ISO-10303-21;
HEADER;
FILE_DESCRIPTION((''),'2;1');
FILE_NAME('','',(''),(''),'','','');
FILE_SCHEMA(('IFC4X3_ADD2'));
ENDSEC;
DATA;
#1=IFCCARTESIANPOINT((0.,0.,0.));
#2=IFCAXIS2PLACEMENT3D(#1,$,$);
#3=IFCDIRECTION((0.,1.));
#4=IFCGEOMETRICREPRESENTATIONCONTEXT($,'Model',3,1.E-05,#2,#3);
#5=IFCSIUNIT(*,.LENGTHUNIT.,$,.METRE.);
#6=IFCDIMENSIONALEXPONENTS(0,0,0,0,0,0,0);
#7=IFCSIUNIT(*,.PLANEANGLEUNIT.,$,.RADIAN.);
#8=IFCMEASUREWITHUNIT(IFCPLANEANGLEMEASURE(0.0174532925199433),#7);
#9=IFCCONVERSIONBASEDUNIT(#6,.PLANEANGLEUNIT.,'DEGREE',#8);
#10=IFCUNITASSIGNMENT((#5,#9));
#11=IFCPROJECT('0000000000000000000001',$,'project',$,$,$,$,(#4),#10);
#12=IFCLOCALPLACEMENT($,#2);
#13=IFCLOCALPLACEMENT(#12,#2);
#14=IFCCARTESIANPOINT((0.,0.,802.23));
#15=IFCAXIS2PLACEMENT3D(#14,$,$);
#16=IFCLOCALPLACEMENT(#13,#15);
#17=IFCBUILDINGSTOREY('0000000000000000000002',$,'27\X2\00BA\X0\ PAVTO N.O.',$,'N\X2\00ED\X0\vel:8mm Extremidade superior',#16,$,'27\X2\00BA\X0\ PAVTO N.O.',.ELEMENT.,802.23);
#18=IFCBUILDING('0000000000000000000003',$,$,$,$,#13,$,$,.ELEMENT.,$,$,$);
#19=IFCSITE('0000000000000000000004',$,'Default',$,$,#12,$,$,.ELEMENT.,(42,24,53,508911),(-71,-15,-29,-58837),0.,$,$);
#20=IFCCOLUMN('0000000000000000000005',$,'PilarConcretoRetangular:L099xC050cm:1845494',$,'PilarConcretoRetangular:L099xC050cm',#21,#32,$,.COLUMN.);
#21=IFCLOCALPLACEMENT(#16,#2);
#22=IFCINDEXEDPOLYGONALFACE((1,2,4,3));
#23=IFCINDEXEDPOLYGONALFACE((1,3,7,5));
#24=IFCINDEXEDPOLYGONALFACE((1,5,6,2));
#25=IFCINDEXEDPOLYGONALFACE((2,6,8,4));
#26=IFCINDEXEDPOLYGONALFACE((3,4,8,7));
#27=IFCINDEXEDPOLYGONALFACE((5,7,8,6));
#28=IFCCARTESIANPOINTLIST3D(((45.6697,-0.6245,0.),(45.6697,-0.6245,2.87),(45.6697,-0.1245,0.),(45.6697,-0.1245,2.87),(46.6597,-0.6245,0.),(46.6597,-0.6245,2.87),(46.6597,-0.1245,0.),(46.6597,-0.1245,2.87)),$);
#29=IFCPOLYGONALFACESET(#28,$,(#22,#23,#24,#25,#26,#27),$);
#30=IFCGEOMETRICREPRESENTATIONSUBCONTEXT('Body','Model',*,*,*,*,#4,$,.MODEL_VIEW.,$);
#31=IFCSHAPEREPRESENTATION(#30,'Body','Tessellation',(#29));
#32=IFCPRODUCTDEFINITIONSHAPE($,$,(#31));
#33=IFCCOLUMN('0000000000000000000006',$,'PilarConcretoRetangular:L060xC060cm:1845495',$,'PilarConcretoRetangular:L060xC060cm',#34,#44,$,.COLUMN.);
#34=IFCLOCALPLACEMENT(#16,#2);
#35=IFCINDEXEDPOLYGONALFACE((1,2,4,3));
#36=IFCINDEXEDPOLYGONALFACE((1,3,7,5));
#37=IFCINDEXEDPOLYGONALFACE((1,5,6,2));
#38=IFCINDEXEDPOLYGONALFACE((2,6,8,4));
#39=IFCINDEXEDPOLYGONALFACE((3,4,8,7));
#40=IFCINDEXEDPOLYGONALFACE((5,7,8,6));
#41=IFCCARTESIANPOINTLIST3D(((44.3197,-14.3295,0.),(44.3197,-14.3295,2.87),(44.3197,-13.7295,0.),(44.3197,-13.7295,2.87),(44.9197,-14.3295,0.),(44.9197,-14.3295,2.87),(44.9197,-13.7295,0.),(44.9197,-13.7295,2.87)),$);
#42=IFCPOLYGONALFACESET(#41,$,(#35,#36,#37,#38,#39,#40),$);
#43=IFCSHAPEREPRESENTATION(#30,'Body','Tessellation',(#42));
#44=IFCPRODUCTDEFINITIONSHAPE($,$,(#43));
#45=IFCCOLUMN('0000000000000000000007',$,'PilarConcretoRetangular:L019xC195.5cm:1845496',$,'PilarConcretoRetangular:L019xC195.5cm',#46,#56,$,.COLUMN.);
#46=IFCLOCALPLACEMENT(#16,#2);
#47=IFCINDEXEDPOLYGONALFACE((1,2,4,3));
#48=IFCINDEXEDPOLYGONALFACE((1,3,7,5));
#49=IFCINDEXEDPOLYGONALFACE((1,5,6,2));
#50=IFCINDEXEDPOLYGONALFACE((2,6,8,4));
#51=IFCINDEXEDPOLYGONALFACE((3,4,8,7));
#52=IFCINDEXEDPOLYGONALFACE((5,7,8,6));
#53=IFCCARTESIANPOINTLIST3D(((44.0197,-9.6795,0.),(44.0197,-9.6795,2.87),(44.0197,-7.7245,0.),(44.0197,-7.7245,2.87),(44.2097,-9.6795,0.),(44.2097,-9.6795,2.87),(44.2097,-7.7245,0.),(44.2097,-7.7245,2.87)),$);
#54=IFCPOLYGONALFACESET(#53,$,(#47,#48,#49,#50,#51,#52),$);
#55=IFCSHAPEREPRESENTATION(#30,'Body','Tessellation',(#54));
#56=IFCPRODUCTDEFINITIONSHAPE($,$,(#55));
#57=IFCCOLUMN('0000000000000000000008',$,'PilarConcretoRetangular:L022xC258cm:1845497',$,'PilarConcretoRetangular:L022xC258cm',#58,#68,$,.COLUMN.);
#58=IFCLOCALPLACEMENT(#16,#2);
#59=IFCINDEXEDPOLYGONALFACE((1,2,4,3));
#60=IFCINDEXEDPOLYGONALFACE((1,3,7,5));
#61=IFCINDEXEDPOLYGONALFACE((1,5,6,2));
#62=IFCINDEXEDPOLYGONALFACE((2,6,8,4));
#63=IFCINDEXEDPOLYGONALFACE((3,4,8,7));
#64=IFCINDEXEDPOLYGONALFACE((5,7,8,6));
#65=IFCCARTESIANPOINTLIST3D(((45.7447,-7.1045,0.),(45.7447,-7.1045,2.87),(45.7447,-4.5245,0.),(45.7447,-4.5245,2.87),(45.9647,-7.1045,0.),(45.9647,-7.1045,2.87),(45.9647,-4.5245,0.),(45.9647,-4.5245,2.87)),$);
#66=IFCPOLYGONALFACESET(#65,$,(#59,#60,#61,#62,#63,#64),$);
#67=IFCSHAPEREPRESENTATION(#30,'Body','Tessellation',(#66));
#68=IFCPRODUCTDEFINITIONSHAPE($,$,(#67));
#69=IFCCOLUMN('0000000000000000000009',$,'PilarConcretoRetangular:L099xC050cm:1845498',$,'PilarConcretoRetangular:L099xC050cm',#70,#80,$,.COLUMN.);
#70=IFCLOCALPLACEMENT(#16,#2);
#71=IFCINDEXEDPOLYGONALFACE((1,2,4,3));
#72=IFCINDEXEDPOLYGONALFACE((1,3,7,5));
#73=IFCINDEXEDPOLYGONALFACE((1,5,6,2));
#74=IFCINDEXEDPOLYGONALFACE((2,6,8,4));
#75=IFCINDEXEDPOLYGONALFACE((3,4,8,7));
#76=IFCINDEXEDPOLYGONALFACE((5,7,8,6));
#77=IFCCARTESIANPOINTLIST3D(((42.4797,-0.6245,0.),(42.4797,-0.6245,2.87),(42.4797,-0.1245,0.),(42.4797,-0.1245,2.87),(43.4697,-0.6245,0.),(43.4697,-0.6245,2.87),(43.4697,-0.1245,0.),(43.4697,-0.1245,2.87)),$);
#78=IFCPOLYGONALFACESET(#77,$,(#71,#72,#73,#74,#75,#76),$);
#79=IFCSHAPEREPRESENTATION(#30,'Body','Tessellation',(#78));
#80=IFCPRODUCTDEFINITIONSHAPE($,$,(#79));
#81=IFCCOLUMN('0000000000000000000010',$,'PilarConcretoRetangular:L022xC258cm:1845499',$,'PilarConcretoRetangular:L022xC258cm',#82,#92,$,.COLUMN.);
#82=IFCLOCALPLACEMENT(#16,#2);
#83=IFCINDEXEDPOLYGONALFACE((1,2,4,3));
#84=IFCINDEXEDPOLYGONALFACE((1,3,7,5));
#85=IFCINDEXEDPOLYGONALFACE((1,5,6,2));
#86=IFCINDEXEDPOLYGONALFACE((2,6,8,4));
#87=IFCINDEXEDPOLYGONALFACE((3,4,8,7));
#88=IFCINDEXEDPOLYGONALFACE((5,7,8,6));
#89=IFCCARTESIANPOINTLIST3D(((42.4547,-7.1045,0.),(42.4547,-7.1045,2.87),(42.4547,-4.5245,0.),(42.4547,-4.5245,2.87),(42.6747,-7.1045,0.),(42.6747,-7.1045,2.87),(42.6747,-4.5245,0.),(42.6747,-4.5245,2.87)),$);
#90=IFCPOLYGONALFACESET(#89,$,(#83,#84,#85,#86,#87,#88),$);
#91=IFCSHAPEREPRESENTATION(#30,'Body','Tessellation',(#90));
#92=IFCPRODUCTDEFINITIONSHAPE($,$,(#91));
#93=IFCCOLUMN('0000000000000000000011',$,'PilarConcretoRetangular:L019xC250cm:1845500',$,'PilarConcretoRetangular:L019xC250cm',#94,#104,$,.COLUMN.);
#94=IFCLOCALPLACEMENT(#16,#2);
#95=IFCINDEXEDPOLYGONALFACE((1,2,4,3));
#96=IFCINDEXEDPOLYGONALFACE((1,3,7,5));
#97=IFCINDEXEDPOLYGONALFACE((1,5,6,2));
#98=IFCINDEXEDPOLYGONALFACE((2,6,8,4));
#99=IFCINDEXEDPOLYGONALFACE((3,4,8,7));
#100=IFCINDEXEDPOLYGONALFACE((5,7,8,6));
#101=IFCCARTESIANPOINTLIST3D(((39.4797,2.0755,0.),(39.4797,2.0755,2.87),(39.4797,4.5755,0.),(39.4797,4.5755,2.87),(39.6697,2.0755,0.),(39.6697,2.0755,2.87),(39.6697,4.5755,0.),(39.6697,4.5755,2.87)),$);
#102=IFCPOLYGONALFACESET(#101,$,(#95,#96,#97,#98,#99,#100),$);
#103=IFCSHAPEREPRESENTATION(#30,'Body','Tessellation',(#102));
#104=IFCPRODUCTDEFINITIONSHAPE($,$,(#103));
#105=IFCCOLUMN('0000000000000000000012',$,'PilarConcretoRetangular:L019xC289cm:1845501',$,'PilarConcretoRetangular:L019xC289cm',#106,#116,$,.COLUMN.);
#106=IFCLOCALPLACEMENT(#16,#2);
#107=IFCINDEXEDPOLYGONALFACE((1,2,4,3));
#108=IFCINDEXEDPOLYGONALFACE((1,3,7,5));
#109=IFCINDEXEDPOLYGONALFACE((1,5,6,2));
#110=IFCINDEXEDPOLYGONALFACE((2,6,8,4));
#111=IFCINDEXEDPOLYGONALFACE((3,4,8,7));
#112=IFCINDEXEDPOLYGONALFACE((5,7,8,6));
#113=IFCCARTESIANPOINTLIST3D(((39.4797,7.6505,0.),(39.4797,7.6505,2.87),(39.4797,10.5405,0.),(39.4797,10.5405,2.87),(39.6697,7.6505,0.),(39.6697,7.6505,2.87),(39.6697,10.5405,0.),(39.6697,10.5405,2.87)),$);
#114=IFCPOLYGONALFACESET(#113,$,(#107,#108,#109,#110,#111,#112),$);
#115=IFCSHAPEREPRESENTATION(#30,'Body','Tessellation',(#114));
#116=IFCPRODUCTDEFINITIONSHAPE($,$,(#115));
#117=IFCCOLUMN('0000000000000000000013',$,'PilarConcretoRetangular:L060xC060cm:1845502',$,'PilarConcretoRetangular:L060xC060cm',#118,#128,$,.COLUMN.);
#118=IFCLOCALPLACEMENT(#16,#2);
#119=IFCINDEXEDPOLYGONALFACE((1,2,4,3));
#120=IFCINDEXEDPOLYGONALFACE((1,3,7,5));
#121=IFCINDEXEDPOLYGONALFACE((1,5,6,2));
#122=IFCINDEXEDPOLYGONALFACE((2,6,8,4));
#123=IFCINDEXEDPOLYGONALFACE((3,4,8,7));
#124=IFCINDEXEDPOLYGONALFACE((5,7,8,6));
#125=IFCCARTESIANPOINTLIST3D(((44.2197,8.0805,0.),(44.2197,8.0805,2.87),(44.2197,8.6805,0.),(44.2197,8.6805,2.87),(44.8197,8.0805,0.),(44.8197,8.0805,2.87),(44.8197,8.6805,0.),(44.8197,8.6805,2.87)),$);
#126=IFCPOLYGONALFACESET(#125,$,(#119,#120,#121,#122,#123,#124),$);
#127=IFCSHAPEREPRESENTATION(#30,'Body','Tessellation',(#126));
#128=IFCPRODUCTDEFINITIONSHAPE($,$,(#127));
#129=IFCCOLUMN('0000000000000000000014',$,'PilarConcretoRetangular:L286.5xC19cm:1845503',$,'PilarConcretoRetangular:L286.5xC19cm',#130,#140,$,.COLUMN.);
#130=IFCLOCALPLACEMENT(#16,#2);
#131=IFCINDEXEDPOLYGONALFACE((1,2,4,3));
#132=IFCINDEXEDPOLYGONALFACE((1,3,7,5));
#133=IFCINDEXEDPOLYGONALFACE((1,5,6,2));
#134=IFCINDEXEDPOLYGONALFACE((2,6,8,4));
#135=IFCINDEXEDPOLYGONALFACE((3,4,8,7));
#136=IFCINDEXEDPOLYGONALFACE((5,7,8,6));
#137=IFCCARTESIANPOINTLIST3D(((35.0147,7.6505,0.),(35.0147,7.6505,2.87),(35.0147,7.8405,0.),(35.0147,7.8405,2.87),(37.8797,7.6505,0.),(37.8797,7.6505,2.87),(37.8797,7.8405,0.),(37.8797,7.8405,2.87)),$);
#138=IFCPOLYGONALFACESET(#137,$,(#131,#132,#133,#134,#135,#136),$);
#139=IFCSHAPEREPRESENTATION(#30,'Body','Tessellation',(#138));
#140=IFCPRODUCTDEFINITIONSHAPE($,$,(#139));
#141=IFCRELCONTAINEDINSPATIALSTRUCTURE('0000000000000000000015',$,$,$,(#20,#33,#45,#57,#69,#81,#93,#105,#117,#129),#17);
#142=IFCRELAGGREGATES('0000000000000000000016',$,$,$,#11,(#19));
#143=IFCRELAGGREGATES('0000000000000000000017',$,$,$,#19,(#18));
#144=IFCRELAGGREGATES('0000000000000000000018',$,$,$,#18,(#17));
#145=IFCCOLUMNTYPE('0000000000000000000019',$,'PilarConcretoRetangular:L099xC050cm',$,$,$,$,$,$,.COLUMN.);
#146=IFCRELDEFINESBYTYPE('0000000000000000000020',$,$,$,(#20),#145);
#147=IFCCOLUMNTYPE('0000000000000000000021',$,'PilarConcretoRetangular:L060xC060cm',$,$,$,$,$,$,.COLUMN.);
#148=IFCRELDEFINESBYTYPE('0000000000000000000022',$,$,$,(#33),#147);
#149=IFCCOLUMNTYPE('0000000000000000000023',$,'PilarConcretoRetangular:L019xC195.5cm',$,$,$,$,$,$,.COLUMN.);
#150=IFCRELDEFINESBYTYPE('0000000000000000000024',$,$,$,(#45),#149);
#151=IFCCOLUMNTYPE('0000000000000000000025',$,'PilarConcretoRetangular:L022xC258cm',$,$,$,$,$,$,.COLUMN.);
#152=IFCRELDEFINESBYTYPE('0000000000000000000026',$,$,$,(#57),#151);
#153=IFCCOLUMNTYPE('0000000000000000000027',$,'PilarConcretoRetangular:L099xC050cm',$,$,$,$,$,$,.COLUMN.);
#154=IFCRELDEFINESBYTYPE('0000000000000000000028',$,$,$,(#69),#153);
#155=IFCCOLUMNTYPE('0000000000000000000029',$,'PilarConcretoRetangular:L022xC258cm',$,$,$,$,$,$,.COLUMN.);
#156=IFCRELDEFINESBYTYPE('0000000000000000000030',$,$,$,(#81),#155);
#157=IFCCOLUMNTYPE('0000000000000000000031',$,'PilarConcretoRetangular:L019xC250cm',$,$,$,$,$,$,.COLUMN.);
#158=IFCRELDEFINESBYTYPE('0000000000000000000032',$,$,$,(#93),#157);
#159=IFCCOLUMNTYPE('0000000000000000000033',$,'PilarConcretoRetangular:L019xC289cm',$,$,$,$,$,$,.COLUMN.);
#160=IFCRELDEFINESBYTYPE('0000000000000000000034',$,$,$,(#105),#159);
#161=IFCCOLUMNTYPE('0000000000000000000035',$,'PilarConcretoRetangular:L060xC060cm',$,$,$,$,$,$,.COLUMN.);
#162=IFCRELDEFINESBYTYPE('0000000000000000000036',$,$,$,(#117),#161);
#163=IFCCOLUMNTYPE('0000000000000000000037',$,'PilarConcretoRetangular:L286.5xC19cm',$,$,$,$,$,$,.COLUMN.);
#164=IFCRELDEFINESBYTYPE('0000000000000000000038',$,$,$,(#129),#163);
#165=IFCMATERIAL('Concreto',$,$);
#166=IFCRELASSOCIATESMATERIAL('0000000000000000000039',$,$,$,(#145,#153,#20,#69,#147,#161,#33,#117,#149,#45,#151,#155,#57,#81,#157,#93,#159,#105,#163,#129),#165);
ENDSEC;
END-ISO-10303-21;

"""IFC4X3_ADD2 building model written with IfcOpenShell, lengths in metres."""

from ifc_helpers import new_model, entity, si_unit, converted_unit, direction, frame, frame_2d, origin, origin_2d_with_axis, place, context, subcontext, project, spatial, rectangle, extrude, source, transform, mapped, material, material_profile, profile_set, profile_usage, type_object, type_shapes, element, save


model = new_model("IFC4X3_ADD2")

# Units and contexts
model_context = context("Model", 3, precision=1e-05, world=origin(), true_north=direction((0.0, 1.0)))
body_context = subcontext(model_context, "Body", "Model", "MODEL_VIEW")
ifc_project = project(units=[si_unit("LENGTHUNIT", "METRE"), converted_unit("PLANEANGLEUNIT", "DEGREE", entity("IfcPlaneAngleMeasure", 0.0174532925199433), si_unit("PLANEANGLEUNIT", "RADIAN"), dimensions=[0, 0, 0, 0, 0, 0, 0])], contexts=[model_context])

# Site, building, storey
site_placement = place(None, origin())
site = spatial("IfcSite", under=ifc_project, at=site_placement, Name="Default", CompositionType="ELEMENT", RefLatitude=(42, 24, 53, 508911), RefLongitude=(-71, -15, -29, -58837), RefElevation=0.0)
building_placement = place(site_placement, origin())
building = spatial("IfcBuilding", under=site, at=building_placement, CompositionType="ELEMENT")
storey_placement = place(building_placement, frame((0.0, 0.0, 802.23)))
storey = spatial("IfcBuildingStorey", under=building, at=storey_placement, Name="27º PAVTO N.O.", ObjectType="Nível:8mm Extremidade superior", LongName="27º PAVTO N.O.", CompositionType="ELEMENT", Elevation=802.23)

# Columns
ifc_material = material(Name="Concreto")
ifc_material_profile_1 = material_profile(ifc_material, rectangle(XDim=0.19, YDim=2.89, at=frame_2d((0.0, 0.0), x_axis=(1.0, 0.0))), Name="L019xC289cm")
ifc_profile_set_1 = profile_set([ifc_material_profile_1], Name="L019xC289cm")
ifc_profile_usage_1 = profile_usage(ifc_profile_set_1)
ifc_material_profile_2 = material_profile(ifc_material, rectangle(XDim=0.19, YDim=2.5, at=frame_2d((0.0, 0.0), x_axis=(1.0, 0.0))), Name="L019xC250cm")
ifc_profile_set_2 = profile_set([ifc_material_profile_2], Name="L019xC250cm")
ifc_profile_usage_2 = profile_usage(ifc_profile_set_2)
ifc_material_profile_3 = material_profile(ifc_material, rectangle(XDim=0.6, YDim=0.6, at=origin_2d_with_axis()), Name="L060xC060cm")
ifc_profile_set_3 = profile_set([ifc_material_profile_3], Name="L060xC060cm")
ifc_profile_usage_3 = profile_usage(ifc_profile_set_3)
ifc_material_profile_4 = material_profile(ifc_material, rectangle(XDim=2.865, YDim=0.19, at=frame_2d((0.0, 0.0), x_axis=(1.0, 0.0))), Name="L286.5xC19cm")
ifc_profile_set_4 = profile_set([ifc_material_profile_4], Name="L286.5xC19cm")
ifc_profile_usage_4 = profile_usage(ifc_profile_set_4)
ifc_material_profile_5 = material_profile(ifc_material, rectangle(XDim=0.19, YDim=1.955, at=frame_2d((0.0, 0.0), x_axis=(1.0, 0.0))), Name="L019xC195.5cm")
ifc_profile_set_5 = profile_set([ifc_material_profile_5], Name="L019xC195.5cm")
ifc_profile_usage_5 = profile_usage(ifc_profile_set_5)
ifc_material_profile_6 = material_profile(ifc_material, rectangle(XDim=0.99, YDim=0.5, at=frame_2d((0.0, 0.0), x_axis=(1.0, 0.0))), Name="L099xC050cm")
ifc_profile_set_6 = profile_set([ifc_material_profile_6], Name="L099xC050cm")
ifc_profile_usage_6 = profile_usage(ifc_profile_set_6)
column_type_1 = type_object("IfcColumnType", Name="PilarConcretoRetangular:L099xC050cm", PredefinedType="COLUMN", material=ifc_profile_set_6)
shared_shape_1 = source(origin(), body_context, "Body", "SweptSolid", [
    extrude(rectangle(XDim=0.99, YDim=0.5, at=frame_2d((0.0, 0.0), x_axis=(1.0, 0.0))), frame((46.1647, -0.3745, 802.23), z_axis=(0.0, 0.0, 1.0), x_axis=(-1.0, 0.0, 0.0)), (0.0, 0.0, 1.0), 2.87),
])
type_shapes(column_type_1, [shared_shape_1])
column_1_placement = place(storey_placement, frame((0.0, 0.0, -802.23)))
element("IfcColumn", 1, at=column_1_placement, inside=storey, type_object=column_type_1, material=ifc_profile_usage_6, Name="PilarConcretoRetangular:L099xC050cm:1845494", ObjectType="PilarConcretoRetangular:L099xC050cm", PredefinedType="COLUMN", context=body_context, shape_type="MappedRepresentation", body=[
    mapped(shared_shape_1, transform((0.0, 0.0, 0.0), scale=1.0)),
])
column_type_2 = type_object("IfcColumnType", Name="PilarConcretoRetangular:L060xC060cm", PredefinedType="COLUMN", material=ifc_profile_set_3)
shared_shape_2 = source(origin(), body_context, "Body", "SweptSolid", [
    extrude(rectangle(XDim=0.6, YDim=0.6, at=frame_2d((0.0, 0.0), x_axis=(1.0, 0.0))), frame((44.6197, -14.0295, 802.23), z_axis=(0.0, 0.0, 1.0), x_axis=(-1.0, 0.0, 0.0)), (0.0, 0.0, 1.0), 2.87),
])
type_shapes(column_type_2, [shared_shape_2])
column_2_placement = place(storey_placement, frame((0.0, 0.0, -802.23)))
element("IfcColumn", 2, at=column_2_placement, inside=storey, type_object=column_type_2, material=ifc_profile_usage_3, Name="PilarConcretoRetangular:L060xC060cm:1845495", ObjectType="PilarConcretoRetangular:L060xC060cm", PredefinedType="COLUMN", context=body_context, shape_type="MappedRepresentation", body=[
    mapped(shared_shape_2, transform((0.0, 0.0, 0.0), scale=1.0)),
])
column_type_3 = type_object("IfcColumnType", Name="PilarConcretoRetangular:L019xC195.5cm", PredefinedType="COLUMN", material=ifc_profile_set_5)
shared_shape_3 = source(origin(), body_context, "Body", "SweptSolid", [
    extrude(rectangle(XDim=0.19, YDim=1.955, at=frame_2d((0.0, 0.0), x_axis=(1.0, 0.0))), frame((44.1147, -8.702, 802.23), z_axis=(0.0, 0.0, 1.0), x_axis=(-1.0, 0.0, 0.0)), (0.0, 0.0, 1.0), 2.87),
])
type_shapes(column_type_3, [shared_shape_3])
column_3_placement = place(storey_placement, frame((0.0, 0.0, -802.23)))
element("IfcColumn", 3, at=column_3_placement, inside=storey, type_object=column_type_3, material=ifc_profile_usage_5, Name="PilarConcretoRetangular:L019xC195.5cm:1845496", ObjectType="PilarConcretoRetangular:L019xC195.5cm", PredefinedType="COLUMN", context=body_context, shape_type="MappedRepresentation", body=[
    mapped(shared_shape_3, transform((0.0, 0.0, 0.0), scale=1.0)),
])
ifc_material_profile_7 = material_profile(ifc_material, rectangle(XDim=0.22, YDim=2.58, at=frame_2d((0.0, 0.0), x_axis=(1.0, 0.0))), Name="L022xC258cm")
ifc_profile_set_7 = profile_set([ifc_material_profile_7], Name="L022xC258cm")
ifc_profile_usage_7 = profile_usage(ifc_profile_set_7)
column_type_4 = type_object("IfcColumnType", Name="PilarConcretoRetangular:L022xC258cm", PredefinedType="COLUMN", material=ifc_profile_set_7)
shared_shape_4 = source(origin(), body_context, "Body", "SweptSolid", [
    extrude(rectangle(XDim=0.22, YDim=2.58, at=frame_2d((0.0, 0.0), x_axis=(1.0, 0.0))), frame((45.8547, -5.8145, 802.23)), (0.0, 0.0, 1.0), 2.87),
])
type_shapes(column_type_4, [shared_shape_4])
column_4_placement = place(storey_placement, frame((0.0, 0.0, -802.23)))
element("IfcColumn", 4, at=column_4_placement, inside=storey, type_object=column_type_4, material=ifc_profile_usage_7, Name="PilarConcretoRetangular:L022xC258cm:1845497", ObjectType="PilarConcretoRetangular:L022xC258cm", PredefinedType="COLUMN", context=body_context, shape_type="MappedRepresentation", body=[
    mapped(shared_shape_4, transform((0.0, 0.0, 0.0), scale=1.0)),
])
column_type_5 = type_object("IfcColumnType", Name="PilarConcretoRetangular:L099xC050cm", PredefinedType="COLUMN", material=ifc_profile_set_6)
shared_shape_5 = source(origin(), body_context, "Body", "SweptSolid", [
    extrude(rectangle(XDim=0.99, YDim=0.5, at=frame_2d((0.0, 0.0), x_axis=(1.0, 0.0))), frame((42.9747, -0.3745, 802.23), z_axis=(0.0, 0.0, 1.0), x_axis=(-1.0, 0.0, 0.0)), (0.0, 0.0, 1.0), 2.87),
])
type_shapes(column_type_5, [shared_shape_5])
column_5_placement = place(storey_placement, frame((0.0, 0.0, -802.23)))
element("IfcColumn", 5, at=column_5_placement, inside=storey, type_object=column_type_5, material=ifc_profile_usage_6, Name="PilarConcretoRetangular:L099xC050cm:1845498", ObjectType="PilarConcretoRetangular:L099xC050cm", PredefinedType="COLUMN", context=body_context, shape_type="MappedRepresentation", body=[
    mapped(shared_shape_5, transform((0.0, 0.0, 0.0), scale=1.0)),
])
column_type_6 = type_object("IfcColumnType", Name="PilarConcretoRetangular:L022xC258cm", PredefinedType="COLUMN", material=ifc_profile_set_7)
shared_shape_6 = source(origin(), body_context, "Body", "SweptSolid", [
    extrude(rectangle(XDim=0.22, YDim=2.58, at=frame_2d((0.0, 0.0), x_axis=(1.0, 0.0))), frame((42.5647, -5.8145, 802.23)), (0.0, 0.0, 1.0), 2.87),
])
type_shapes(column_type_6, [shared_shape_6])
column_6_placement = place(storey_placement, frame((0.0, 0.0, -802.23)))
element("IfcColumn", 6, at=column_6_placement, inside=storey, type_object=column_type_6, material=ifc_profile_usage_7, Name="PilarConcretoRetangular:L022xC258cm:1845499", ObjectType="PilarConcretoRetangular:L022xC258cm", PredefinedType="COLUMN", context=body_context, shape_type="MappedRepresentation", body=[
    mapped(shared_shape_6, transform((0.0, 0.0, 0.0), scale=1.0)),
])
column_type_7 = type_object("IfcColumnType", Name="PilarConcretoRetangular:L019xC250cm", PredefinedType="COLUMN", material=ifc_profile_set_2)
shared_shape_7 = source(origin(), body_context, "Body", "SweptSolid", [
    extrude(rectangle(XDim=0.19, YDim=2.5, at=frame_2d((0.0, 0.0), x_axis=(1.0, 0.0))), frame((39.5747, 3.3255, 802.23), z_axis=(0.0, 0.0, 1.0), x_axis=(-1.0, 0.0, 0.0)), (0.0, 0.0, 1.0), 2.87),
])
type_shapes(column_type_7, [shared_shape_7])
column_7_placement = place(storey_placement, frame((0.0, 0.0, -802.23)))
element("IfcColumn", 7, at=column_7_placement, inside=storey, type_object=column_type_7, material=ifc_profile_usage_2, Name="PilarConcretoRetangular:L019xC250cm:1845500", ObjectType="PilarConcretoRetangular:L019xC250cm", PredefinedType="COLUMN", context=body_context, shape_type="MappedRepresentation", body=[
    mapped(shared_shape_7, transform((0.0, 0.0, 0.0), scale=1.0)),
])
column_type_8 = type_object("IfcColumnType", Name="PilarConcretoRetangular:L019xC289cm", PredefinedType="COLUMN", material=ifc_profile_set_1)
shared_shape_8 = source(origin(), body_context, "Body", "SweptSolid", [
    extrude(rectangle(XDim=0.19, YDim=2.89, at=frame_2d((0.0, 0.0), x_axis=(1.0, 0.0))), frame((39.5747, 9.0955, 802.23), z_axis=(0.0, 0.0, 1.0), x_axis=(-1.0, 0.0, 0.0)), (0.0, 0.0, 1.0), 2.87),
])
type_shapes(column_type_8, [shared_shape_8])
column_8_placement = place(storey_placement, frame((0.0, 0.0, -802.23)))
element("IfcColumn", 8, at=column_8_placement, inside=storey, type_object=column_type_8, material=ifc_profile_usage_1, Name="PilarConcretoRetangular:L019xC289cm:1845501", ObjectType="PilarConcretoRetangular:L019xC289cm", PredefinedType="COLUMN", context=body_context, shape_type="MappedRepresentation", body=[
    mapped(shared_shape_8, transform((0.0, 0.0, 0.0), scale=1.0)),
])
column_type_9 = type_object("IfcColumnType", Name="PilarConcretoRetangular:L060xC060cm", PredefinedType="COLUMN", material=ifc_profile_set_3)
shared_shape_9 = source(origin(), body_context, "Body", "SweptSolid", [
    extrude(rectangle(XDim=0.6, YDim=0.6, at=origin_2d_with_axis()), frame((44.5197, 8.3805, 802.23), z_axis=(0.0, 0.0, 1.0), x_axis=(-1.0, 0.0, 0.0)), (0.0, 0.0, 1.0), 2.87),
])
type_shapes(column_type_9, [shared_shape_9])
column_9_placement = place(storey_placement, frame((0.0, 0.0, -802.23)))
element("IfcColumn", 9, at=column_9_placement, inside=storey, type_object=column_type_9, material=ifc_profile_usage_3, Name="PilarConcretoRetangular:L060xC060cm:1845502", ObjectType="PilarConcretoRetangular:L060xC060cm", PredefinedType="COLUMN", context=body_context, shape_type="MappedRepresentation", body=[
    mapped(shared_shape_9, transform((0.0, 0.0, 0.0), scale=1.0)),
])
column_type_10 = type_object("IfcColumnType", Name="PilarConcretoRetangular:L286.5xC19cm", PredefinedType="COLUMN", material=ifc_profile_set_4)
shared_shape_10 = source(origin(), body_context, "Body", "SweptSolid", [
    extrude(rectangle(XDim=2.865, YDim=0.19, at=frame_2d((0.0, 0.0), x_axis=(1.0, 0.0))), frame((36.4472, 7.7455, 802.23), z_axis=(0.0, 0.0, 1.0), x_axis=(-1.0, 0.0, 0.0)), (0.0, 0.0, 1.0), 2.87),
])
type_shapes(column_type_10, [shared_shape_10])
column_10_placement = place(storey_placement, frame((0.0, 0.0, -802.23)))
element("IfcColumn", 10, at=column_10_placement, inside=storey, type_object=column_type_10, material=ifc_profile_usage_4, Name="PilarConcretoRetangular:L286.5xC19cm:1845503", ObjectType="PilarConcretoRetangular:L286.5xC19cm", PredefinedType="COLUMN", context=body_context, shape_type="MappedRepresentation", body=[
    mapped(shared_shape_10, transform((0.0, 0.0, 0.0), scale=1.0)),
])

save(model, "model.ifc")
